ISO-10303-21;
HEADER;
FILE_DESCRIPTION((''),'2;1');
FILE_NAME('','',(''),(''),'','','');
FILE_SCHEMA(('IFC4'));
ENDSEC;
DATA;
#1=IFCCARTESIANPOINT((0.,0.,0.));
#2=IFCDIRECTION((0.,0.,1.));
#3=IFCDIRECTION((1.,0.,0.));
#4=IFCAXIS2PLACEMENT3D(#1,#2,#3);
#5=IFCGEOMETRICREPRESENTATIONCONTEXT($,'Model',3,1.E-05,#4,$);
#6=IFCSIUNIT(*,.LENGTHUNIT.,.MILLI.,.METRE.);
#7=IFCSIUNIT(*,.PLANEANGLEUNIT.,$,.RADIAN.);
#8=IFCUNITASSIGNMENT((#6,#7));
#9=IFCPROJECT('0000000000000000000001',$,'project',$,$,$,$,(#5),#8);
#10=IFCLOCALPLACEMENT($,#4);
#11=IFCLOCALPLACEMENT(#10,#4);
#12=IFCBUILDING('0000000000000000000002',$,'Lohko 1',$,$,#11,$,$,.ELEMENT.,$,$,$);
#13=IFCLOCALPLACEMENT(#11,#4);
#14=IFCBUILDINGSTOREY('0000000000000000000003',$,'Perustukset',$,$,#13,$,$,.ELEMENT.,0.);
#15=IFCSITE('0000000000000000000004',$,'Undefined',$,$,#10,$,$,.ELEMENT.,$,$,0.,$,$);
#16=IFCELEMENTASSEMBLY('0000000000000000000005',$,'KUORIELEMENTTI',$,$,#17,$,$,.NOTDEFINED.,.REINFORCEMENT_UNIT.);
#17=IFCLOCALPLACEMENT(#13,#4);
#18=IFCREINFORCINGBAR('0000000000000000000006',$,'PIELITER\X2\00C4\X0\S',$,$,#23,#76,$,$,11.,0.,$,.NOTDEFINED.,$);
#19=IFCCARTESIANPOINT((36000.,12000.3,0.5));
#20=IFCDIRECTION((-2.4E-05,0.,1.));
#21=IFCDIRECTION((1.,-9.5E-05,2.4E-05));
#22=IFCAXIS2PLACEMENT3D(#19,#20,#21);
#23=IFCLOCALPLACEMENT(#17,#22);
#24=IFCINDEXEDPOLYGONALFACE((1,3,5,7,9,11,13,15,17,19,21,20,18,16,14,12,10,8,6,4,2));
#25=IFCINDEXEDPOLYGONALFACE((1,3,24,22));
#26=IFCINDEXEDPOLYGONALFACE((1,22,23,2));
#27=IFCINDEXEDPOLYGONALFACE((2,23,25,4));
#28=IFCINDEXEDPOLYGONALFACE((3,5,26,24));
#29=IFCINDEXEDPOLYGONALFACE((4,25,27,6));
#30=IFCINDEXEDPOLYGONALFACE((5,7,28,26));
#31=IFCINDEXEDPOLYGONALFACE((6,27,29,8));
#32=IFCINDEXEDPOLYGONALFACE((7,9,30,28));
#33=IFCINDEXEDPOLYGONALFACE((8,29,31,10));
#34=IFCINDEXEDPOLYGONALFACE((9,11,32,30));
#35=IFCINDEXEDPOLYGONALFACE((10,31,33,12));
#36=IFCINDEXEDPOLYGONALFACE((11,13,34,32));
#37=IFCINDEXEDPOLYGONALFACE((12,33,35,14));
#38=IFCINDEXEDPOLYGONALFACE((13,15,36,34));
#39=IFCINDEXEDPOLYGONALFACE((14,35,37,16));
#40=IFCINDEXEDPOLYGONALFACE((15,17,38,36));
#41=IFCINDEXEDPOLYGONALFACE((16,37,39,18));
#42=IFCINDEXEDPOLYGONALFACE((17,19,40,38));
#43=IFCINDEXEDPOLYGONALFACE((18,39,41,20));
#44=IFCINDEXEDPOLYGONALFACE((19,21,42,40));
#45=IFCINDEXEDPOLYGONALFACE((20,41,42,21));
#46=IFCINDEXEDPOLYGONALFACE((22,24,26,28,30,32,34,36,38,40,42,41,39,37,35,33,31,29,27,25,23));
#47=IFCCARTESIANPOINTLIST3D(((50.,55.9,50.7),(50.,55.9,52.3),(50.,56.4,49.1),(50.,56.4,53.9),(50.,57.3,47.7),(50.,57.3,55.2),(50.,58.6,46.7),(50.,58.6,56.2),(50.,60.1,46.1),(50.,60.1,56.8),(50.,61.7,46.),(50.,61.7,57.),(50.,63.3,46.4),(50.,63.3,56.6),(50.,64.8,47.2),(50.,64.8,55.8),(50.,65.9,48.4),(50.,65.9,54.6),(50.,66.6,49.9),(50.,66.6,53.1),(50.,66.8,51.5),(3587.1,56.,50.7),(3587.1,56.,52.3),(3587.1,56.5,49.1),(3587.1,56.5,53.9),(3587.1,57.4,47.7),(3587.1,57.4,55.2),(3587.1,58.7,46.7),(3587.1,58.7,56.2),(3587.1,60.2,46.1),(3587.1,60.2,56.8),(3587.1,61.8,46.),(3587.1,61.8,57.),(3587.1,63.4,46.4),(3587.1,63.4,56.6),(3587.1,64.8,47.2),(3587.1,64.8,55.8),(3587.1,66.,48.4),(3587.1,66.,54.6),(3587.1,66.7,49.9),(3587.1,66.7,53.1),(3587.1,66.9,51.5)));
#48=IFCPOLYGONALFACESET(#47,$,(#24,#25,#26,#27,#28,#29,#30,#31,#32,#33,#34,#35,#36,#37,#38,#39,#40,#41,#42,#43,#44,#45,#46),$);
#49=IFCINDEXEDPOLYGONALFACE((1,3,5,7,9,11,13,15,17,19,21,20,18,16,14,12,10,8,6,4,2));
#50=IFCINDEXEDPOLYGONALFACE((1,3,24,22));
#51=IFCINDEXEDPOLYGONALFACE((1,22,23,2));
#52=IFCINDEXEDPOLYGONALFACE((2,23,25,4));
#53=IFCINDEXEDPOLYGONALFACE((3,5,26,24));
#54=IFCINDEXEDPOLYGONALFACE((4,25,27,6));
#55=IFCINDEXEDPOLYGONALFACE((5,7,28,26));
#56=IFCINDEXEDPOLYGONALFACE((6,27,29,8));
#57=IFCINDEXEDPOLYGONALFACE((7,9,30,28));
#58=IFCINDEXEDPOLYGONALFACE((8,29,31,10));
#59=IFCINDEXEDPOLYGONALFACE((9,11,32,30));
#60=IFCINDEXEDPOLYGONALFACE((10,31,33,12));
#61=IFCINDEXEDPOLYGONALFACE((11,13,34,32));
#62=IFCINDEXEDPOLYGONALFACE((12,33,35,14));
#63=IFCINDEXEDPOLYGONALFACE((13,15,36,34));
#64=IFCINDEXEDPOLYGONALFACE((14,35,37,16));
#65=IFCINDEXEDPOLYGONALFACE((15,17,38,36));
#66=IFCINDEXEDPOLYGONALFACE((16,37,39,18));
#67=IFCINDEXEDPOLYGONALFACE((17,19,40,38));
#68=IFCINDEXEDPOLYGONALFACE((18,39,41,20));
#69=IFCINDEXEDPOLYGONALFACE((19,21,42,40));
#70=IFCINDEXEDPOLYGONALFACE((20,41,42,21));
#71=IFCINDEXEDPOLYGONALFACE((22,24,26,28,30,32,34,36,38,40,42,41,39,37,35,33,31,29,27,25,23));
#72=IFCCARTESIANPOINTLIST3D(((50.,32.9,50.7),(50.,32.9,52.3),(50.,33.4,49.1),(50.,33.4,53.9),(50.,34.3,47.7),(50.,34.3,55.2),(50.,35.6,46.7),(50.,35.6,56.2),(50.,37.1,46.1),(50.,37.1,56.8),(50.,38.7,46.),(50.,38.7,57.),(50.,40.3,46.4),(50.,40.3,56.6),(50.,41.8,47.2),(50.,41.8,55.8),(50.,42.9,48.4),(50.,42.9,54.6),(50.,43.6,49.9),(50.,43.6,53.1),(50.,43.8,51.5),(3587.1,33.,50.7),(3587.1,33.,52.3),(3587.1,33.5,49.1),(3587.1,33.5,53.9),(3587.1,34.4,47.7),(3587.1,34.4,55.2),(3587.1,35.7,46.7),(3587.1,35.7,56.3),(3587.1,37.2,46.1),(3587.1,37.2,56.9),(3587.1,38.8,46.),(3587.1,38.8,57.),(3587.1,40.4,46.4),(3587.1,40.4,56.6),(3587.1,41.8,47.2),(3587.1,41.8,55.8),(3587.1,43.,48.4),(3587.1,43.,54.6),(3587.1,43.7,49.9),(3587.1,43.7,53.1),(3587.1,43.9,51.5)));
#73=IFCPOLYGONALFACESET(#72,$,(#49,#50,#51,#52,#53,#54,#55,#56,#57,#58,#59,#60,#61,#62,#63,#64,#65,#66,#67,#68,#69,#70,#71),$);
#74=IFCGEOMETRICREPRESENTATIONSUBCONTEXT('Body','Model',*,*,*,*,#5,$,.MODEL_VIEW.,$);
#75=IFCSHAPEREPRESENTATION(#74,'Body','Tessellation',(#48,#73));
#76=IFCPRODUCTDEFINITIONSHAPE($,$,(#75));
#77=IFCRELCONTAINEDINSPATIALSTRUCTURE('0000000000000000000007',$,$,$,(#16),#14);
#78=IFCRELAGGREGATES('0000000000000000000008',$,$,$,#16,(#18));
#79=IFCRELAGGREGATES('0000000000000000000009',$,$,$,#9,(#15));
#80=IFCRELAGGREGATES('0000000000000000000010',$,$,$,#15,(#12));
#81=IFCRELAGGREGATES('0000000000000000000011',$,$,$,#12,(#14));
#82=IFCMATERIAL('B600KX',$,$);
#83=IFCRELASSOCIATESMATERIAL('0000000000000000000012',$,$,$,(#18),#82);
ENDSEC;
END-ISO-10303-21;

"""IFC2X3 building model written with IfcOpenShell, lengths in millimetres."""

from ifc_helpers import new_model, entity, si_unit, frame, origin_with_axes, place, context, subcontext, project, spatial, source, transform, mapped, material, element, aggregate, save


model = new_model("IFC2X3")

# Units and contexts
model_context = context("Model", 3, precision=1e-05, world=origin_with_axes())
body_context = subcontext(model_context, "Body", "Model", "MODEL_VIEW")
ifc_project = project(units=[si_unit("LENGTHUNIT", "METRE", prefix="MILLI"), si_unit("PLANEANGLEUNIT", "RADIAN")], contexts=[model_context])

# Site, building, storey
site_placement = place(None, origin_with_axes())
site = spatial("IfcSite", under=ifc_project, at=site_placement, Name="Undefined", CompositionType="ELEMENT", RefElevation=0.0)
building_placement = place(site_placement, origin_with_axes())
building = spatial("IfcBuilding", under=site, at=building_placement, Name="Lohko 1", CompositionType="ELEMENT")
storey_placement = place(building_placement, origin_with_axes())
storey = spatial("IfcBuildingStorey", under=building, at=storey_placement, Name="Perustukset", CompositionType="ELEMENT", Elevation=0.0)

# Element assembly, reinforcing bar
assembly_placement = place(storey_placement, origin_with_axes())
assembly = element("IfcElementAssembly", 1, at=assembly_placement, inside=storey, Name="KUORIELEMENTTI", AssemblyPlace="NOTDEFINED", PredefinedType="REINFORCEMENT_UNIT")
ifc_material = material(Name="B600KX")
shared_shape_1 = source(origin_with_axes(), body_context, "Body", "AdvancedSweptSolid", [
    entity("IfcSweptDiskSolid", entity("IfcTrimmedCurve", entity("IfcLine", entity("IfcCartesianPoint", [0.0, 0.0, 0.0]), entity("IfcVector", entity("IfcDirection", [1.0, 0.00002, 0.000002]), 1.0)), [entity("IfcParameterValue", 0.0)], [entity("IfcParameterValue", 3537.099474)], True, "PARAMETER"), 5.5, None, 0.0, 3537.1),
])
shared_shape_2 = source(origin_with_axes(), body_context, "Body", "AdvancedSweptSolid", [
    entity("IfcSweptDiskSolid", entity("IfcTrimmedCurve", entity("IfcLine", entity("IfcCartesianPoint", [0.0, 0.0, 0.0]), entity("IfcVector", entity("IfcDirection", [1.0, 0.00002, 0.000002]), 1.0)), [entity("IfcParameterValue", 0.0)], [entity("IfcParameterValue", 3537.099474)], True, "PARAMETER"), 5.5, None, 0.0, 3537.1),
])
reinforcing_bar_1_placement = place(assembly_placement, frame((36000.0, 12000.3, 0.5), z_axis=(-0.000024, 0.0, 1.0), x_axis=(1.0, -0.000095, 0.000024)))
reinforcing_bar_1 = element("IfcReinforcingBar", 2, at=reinforcing_bar_1_placement, material=ifc_material, Name="PIELITERÄS", BarRole="NOTDEFINED", CrossSectionArea=0.0, NominalDiameter=11.0, context=body_context, shape_type="MappedRepresentation", body=[
    mapped(shared_shape_1, transform((50.0, 61.3, 51.5))),
    mapped(shared_shape_2, transform((50.0, 38.3, 51.5))),
])
aggregate(assembly, [reinforcing_bar_1])

save(model, "model.ifc")
